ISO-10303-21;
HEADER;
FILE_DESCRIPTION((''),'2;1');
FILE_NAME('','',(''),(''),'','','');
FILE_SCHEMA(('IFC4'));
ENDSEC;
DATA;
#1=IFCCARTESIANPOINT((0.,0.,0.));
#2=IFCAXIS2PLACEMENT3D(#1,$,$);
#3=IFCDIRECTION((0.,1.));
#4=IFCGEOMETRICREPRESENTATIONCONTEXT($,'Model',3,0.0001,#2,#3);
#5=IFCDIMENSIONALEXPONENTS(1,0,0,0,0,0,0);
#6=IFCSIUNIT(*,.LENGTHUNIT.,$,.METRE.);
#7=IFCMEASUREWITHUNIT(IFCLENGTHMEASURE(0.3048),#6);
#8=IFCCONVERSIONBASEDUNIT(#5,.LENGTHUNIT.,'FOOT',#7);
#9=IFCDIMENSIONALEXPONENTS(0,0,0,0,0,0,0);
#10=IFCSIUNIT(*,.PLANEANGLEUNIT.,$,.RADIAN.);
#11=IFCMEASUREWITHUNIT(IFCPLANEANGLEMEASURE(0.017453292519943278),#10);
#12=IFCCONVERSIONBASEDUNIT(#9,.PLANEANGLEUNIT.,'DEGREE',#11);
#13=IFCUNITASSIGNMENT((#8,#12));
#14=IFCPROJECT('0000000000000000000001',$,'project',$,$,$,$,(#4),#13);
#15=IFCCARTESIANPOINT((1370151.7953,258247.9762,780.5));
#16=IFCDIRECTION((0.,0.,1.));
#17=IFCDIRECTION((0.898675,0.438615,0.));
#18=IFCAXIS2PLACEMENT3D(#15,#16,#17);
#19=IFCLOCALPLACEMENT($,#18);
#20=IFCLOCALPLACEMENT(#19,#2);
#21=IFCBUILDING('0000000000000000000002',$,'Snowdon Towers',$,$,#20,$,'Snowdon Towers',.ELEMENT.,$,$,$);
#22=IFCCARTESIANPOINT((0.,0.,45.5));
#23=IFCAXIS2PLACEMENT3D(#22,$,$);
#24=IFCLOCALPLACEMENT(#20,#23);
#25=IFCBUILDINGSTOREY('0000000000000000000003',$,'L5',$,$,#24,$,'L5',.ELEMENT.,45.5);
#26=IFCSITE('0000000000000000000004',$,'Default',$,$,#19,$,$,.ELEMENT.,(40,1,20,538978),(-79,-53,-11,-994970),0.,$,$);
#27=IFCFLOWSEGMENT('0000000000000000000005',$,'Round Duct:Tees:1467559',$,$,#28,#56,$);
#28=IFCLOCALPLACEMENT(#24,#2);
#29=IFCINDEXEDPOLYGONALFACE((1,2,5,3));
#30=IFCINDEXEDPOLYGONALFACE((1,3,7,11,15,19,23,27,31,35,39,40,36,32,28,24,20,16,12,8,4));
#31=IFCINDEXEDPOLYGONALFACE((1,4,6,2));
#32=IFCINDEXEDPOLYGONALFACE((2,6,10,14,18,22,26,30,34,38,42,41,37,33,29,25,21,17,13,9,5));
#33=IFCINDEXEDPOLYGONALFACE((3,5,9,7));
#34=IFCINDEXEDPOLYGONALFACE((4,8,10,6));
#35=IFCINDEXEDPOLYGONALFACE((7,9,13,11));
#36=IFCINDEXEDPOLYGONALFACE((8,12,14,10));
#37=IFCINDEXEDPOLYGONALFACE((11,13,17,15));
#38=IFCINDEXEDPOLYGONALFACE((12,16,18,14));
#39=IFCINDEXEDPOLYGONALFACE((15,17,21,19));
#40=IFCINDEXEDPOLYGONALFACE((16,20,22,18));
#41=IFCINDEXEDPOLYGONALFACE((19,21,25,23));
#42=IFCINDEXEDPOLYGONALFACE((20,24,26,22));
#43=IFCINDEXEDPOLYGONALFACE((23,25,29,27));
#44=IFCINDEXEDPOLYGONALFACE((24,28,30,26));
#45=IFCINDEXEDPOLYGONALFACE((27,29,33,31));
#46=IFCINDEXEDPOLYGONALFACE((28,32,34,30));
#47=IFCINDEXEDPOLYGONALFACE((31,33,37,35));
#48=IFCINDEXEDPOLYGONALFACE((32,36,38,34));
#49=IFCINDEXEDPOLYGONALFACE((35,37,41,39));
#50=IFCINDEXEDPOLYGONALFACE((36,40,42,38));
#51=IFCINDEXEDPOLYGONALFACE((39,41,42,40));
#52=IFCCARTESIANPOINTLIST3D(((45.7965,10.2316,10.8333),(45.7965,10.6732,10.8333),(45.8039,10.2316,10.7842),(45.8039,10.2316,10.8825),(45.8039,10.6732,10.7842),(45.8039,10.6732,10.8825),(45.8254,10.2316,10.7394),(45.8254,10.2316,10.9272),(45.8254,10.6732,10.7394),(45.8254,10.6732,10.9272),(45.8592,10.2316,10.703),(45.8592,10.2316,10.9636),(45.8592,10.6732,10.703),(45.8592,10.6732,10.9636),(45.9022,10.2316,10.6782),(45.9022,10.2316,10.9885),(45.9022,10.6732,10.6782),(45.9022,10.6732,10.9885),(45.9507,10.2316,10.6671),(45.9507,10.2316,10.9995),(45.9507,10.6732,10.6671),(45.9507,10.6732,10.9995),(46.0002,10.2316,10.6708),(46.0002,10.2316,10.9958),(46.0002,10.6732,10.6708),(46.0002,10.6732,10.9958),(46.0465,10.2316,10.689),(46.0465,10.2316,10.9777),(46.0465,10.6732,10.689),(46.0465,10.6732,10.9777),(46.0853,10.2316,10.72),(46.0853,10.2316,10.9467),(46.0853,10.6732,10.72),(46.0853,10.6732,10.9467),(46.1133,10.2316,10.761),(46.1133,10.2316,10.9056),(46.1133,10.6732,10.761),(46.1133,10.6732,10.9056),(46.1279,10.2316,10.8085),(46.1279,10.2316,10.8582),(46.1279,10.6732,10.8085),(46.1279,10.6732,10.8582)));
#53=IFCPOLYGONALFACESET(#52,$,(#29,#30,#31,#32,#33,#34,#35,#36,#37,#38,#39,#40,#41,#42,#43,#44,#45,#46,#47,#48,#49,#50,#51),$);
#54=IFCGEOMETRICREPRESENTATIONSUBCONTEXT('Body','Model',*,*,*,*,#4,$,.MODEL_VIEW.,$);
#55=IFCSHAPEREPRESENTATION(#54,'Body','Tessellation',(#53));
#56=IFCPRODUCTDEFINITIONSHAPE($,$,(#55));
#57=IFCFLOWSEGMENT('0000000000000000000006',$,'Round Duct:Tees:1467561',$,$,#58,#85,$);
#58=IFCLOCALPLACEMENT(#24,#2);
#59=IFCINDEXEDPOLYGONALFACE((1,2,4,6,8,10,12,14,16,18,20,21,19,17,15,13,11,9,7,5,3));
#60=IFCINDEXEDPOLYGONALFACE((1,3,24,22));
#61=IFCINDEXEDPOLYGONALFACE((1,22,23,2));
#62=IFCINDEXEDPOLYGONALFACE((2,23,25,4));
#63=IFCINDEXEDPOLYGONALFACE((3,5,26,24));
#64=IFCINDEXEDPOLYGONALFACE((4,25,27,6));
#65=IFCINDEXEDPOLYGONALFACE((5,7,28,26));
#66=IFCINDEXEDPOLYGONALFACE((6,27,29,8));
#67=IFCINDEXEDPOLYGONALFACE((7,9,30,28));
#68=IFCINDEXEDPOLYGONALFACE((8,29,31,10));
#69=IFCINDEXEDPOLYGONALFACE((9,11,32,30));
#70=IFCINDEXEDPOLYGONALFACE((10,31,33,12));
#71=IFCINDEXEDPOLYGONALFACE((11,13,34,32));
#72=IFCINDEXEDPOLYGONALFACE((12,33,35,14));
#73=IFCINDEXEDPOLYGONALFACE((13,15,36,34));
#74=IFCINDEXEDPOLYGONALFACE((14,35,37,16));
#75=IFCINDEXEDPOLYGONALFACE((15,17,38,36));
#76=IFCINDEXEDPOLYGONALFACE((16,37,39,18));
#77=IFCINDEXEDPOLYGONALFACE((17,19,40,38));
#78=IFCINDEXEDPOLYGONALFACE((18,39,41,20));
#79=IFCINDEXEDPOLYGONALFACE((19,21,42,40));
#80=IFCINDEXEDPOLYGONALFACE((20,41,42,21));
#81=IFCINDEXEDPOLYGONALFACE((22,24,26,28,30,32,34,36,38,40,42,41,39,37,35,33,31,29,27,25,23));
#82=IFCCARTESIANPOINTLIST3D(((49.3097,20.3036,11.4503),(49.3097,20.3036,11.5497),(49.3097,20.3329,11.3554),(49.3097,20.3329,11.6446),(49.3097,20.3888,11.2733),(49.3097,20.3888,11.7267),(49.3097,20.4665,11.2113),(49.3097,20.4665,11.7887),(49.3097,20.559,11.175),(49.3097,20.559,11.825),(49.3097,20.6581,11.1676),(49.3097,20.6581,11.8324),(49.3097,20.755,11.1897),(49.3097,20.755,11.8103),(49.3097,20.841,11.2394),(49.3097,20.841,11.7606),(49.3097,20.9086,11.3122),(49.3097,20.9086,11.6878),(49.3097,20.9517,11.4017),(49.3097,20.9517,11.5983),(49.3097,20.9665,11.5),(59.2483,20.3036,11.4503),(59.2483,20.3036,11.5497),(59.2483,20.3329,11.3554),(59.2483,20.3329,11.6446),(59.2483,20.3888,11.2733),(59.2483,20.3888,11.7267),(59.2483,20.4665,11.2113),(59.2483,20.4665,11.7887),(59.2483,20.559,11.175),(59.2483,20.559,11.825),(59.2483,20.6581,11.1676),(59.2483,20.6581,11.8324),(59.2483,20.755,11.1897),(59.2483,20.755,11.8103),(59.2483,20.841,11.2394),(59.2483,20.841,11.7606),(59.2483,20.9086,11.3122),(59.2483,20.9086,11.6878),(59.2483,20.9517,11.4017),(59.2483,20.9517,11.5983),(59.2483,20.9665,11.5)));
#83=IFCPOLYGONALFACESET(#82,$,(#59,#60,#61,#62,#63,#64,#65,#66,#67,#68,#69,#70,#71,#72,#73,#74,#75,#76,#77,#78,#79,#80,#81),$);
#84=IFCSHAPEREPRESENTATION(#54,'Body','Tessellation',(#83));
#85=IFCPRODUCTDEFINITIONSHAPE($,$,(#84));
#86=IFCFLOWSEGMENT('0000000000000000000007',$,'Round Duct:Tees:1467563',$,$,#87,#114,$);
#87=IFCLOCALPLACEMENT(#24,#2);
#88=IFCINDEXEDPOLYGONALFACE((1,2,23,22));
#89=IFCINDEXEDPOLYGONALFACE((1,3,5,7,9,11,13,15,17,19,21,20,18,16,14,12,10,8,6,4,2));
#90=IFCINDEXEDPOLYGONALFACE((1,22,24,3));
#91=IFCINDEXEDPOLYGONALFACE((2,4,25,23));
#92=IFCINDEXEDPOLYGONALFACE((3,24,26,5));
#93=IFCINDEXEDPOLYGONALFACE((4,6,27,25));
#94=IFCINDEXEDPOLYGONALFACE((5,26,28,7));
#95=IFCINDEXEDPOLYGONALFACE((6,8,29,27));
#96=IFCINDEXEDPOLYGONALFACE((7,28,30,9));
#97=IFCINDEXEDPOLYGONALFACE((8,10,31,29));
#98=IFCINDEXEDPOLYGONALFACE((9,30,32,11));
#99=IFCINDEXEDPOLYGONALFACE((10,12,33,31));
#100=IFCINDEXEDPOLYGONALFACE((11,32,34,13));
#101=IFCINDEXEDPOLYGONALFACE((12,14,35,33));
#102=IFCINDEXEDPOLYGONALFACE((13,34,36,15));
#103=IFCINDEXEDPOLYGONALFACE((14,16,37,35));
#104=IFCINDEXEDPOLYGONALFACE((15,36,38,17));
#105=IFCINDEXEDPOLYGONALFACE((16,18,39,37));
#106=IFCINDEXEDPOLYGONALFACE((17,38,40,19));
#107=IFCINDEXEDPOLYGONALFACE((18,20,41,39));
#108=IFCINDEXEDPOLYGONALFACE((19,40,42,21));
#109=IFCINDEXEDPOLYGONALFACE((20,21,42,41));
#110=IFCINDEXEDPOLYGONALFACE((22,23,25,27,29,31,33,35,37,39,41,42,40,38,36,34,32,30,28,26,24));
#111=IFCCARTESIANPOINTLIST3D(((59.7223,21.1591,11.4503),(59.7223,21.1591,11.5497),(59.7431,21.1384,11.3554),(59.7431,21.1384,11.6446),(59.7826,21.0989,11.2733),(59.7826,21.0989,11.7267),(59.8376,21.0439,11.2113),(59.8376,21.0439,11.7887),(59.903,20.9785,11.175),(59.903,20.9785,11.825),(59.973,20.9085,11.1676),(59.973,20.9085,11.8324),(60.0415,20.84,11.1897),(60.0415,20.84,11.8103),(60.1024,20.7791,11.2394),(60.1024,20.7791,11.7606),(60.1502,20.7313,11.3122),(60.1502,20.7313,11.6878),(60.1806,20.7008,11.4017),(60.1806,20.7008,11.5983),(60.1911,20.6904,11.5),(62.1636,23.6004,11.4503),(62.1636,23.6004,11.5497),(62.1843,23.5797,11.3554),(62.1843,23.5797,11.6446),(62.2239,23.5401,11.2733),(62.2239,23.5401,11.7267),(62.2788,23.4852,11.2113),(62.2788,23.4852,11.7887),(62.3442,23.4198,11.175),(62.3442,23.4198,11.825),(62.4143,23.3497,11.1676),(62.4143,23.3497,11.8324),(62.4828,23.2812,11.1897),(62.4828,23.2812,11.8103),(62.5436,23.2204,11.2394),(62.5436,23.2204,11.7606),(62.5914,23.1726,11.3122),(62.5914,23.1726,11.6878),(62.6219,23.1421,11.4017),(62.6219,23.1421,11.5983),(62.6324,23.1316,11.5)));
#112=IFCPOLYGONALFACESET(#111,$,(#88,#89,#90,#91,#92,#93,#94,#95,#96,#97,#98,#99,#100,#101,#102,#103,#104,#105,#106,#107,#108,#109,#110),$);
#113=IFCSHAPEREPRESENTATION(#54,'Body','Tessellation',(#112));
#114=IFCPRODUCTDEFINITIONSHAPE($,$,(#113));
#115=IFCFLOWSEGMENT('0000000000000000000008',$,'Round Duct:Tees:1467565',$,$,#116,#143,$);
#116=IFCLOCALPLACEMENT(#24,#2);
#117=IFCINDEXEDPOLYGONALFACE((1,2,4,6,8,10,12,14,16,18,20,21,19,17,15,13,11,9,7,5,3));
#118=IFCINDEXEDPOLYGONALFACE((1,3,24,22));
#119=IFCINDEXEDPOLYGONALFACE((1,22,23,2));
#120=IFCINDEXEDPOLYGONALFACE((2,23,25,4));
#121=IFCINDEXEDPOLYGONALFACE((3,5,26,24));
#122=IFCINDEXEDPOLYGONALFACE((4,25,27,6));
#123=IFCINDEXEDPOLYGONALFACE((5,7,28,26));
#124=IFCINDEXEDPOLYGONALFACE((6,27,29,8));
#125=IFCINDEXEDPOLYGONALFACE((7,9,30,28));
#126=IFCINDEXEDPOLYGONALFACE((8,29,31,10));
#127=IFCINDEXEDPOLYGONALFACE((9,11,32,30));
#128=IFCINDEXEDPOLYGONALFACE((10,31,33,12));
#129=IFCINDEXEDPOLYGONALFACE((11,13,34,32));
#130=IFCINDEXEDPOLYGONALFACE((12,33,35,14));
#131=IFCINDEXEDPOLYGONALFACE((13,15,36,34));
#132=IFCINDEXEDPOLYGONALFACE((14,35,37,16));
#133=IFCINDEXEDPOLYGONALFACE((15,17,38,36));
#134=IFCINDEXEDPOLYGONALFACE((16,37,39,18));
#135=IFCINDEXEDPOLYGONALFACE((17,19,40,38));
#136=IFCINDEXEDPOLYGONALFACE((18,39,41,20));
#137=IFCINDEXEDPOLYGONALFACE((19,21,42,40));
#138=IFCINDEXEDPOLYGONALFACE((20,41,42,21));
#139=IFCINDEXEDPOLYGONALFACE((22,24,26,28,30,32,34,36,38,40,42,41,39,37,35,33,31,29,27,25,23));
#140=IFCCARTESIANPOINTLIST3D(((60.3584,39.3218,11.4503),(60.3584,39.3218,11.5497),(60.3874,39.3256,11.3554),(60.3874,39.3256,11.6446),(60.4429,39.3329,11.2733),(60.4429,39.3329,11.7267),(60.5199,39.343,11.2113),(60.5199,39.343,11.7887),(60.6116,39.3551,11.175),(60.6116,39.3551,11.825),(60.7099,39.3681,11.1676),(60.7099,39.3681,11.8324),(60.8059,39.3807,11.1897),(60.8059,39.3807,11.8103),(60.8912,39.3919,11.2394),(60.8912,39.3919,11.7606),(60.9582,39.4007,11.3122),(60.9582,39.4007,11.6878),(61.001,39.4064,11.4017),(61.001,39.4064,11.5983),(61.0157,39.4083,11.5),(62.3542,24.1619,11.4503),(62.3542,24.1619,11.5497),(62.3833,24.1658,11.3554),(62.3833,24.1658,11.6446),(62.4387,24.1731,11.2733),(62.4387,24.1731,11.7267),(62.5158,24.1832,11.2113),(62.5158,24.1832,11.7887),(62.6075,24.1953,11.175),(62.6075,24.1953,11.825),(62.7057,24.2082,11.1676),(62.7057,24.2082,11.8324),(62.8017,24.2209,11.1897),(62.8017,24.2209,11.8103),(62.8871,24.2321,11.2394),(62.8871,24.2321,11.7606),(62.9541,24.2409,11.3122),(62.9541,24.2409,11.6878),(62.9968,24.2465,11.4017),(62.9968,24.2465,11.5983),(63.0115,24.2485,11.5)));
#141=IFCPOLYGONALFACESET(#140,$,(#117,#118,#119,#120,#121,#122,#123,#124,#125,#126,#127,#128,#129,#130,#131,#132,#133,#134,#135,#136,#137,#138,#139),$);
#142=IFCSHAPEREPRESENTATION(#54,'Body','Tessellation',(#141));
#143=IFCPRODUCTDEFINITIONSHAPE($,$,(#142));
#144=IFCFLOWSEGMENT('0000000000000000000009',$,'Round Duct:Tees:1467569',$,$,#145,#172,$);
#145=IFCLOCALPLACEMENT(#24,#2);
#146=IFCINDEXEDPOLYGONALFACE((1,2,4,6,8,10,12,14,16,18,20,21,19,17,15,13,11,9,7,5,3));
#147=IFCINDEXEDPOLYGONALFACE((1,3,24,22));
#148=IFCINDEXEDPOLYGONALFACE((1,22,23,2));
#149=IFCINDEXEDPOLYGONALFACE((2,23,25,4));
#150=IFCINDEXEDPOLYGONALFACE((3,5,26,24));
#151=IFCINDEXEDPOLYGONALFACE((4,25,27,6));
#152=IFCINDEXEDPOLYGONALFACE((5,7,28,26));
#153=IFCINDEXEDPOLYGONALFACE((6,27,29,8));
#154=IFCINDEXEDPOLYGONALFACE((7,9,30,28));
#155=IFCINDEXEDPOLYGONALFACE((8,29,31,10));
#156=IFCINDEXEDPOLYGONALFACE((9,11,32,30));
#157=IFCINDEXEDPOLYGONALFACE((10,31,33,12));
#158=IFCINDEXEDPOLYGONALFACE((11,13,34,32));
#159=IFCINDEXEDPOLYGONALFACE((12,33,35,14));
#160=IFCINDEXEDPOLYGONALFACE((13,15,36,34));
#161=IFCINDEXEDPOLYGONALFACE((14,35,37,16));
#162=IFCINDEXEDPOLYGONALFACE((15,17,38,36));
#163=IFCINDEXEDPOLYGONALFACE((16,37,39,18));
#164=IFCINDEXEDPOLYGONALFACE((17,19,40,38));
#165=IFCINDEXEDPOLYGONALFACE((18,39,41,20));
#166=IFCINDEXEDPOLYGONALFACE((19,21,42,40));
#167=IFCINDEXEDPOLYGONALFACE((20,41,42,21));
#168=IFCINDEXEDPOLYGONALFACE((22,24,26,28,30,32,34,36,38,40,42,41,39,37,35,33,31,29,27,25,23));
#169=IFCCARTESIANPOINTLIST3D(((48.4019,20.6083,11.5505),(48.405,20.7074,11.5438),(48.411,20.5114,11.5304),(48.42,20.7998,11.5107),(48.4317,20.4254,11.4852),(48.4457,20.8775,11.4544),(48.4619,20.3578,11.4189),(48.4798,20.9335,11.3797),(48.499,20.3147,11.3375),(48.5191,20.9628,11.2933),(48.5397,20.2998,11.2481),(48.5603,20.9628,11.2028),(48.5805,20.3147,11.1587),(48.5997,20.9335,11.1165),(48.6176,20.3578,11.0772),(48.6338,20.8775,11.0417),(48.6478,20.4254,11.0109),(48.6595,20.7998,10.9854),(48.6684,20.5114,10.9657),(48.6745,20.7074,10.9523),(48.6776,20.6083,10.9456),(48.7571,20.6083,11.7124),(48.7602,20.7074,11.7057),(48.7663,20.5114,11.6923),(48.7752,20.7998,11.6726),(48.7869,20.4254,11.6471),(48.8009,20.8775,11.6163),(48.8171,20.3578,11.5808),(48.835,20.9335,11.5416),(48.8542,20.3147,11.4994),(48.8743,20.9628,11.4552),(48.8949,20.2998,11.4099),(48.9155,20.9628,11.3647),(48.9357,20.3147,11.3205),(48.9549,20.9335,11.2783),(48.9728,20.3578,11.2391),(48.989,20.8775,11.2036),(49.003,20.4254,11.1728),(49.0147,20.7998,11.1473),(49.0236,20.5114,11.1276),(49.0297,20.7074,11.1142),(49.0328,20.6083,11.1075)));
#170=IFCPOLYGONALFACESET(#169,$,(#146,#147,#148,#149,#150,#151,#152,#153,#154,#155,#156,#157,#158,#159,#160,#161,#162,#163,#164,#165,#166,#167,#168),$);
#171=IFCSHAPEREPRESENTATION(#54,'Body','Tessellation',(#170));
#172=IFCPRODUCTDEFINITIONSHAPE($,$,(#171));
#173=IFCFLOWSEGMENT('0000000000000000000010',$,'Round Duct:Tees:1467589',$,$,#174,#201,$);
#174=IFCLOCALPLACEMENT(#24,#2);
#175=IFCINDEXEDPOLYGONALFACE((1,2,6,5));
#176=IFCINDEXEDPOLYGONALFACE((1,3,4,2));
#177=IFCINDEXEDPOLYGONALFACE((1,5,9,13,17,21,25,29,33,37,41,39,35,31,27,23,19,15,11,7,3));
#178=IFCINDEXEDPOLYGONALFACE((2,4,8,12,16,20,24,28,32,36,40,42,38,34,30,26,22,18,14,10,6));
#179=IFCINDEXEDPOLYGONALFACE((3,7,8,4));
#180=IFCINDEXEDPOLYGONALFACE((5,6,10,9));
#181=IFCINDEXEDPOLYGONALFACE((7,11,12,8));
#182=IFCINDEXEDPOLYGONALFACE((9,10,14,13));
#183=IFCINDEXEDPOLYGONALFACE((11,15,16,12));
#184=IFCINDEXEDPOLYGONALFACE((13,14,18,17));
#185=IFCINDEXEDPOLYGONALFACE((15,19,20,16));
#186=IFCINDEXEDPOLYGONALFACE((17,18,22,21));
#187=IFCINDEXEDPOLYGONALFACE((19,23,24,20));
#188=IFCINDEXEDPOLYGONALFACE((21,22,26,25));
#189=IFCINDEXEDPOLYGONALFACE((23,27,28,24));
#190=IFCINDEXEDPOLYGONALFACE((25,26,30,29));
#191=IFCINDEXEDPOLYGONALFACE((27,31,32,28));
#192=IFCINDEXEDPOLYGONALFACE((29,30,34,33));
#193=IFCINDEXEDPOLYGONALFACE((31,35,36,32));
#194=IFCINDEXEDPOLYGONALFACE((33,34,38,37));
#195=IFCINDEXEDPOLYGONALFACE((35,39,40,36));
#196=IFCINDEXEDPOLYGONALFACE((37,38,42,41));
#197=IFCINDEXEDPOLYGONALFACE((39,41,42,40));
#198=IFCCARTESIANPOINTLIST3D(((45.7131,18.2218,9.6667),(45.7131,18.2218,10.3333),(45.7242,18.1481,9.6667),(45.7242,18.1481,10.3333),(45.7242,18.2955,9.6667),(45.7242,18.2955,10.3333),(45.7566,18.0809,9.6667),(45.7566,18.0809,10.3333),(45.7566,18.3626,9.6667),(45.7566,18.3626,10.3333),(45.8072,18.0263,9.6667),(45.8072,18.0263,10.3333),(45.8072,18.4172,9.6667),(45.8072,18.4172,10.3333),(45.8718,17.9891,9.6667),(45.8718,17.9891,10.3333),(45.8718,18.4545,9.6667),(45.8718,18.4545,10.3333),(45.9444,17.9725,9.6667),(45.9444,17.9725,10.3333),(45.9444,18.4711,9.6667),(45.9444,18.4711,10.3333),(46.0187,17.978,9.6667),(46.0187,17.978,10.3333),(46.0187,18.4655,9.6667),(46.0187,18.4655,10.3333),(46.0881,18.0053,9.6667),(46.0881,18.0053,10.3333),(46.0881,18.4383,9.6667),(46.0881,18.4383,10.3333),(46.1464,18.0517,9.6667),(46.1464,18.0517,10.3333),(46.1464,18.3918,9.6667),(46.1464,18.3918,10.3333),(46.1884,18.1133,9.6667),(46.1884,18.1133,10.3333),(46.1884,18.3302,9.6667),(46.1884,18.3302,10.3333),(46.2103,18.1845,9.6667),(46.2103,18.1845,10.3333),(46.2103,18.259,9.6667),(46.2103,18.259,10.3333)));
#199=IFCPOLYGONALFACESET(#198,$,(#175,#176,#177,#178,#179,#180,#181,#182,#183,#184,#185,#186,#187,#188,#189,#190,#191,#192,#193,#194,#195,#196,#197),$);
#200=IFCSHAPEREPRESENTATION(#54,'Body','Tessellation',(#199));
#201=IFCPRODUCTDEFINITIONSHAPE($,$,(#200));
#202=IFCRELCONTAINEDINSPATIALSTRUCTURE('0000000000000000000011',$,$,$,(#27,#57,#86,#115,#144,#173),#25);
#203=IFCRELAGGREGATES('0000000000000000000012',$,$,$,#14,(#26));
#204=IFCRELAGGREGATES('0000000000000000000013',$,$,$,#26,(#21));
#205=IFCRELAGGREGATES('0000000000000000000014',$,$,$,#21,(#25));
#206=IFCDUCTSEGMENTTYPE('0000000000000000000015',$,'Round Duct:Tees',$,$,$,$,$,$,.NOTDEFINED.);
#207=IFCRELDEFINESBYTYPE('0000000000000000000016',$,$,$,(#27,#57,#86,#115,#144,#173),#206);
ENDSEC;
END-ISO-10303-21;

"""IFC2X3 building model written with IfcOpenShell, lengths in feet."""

from ifc_helpers import new_model, entity, si_unit, converted_unit, direction, frame, frame_2d, origin, origin_2d_with_axis, place, context, subcontext, project, spatial, circle, extrude, type_object, element, save


model = new_model("IFC2X3")

# Units and contexts
model_context = context("Model", 3, precision=0.0001, world=origin(), true_north=direction((0.0, 1.0)))
body_context = subcontext(model_context, "Body", "Model", "MODEL_VIEW")
ifc_project = project(units=[converted_unit("LENGTHUNIT", "FOOT", entity("IfcLengthMeasure", 0.3048), si_unit("LENGTHUNIT", "METRE"), dimensions=[1, 0, 0, 0, 0, 0, 0]), converted_unit("PLANEANGLEUNIT", "DEGREE", entity("IfcPlaneAngleMeasure", 0.017453292519943278), si_unit("PLANEANGLEUNIT", "RADIAN"), dimensions=[0, 0, 0, 0, 0, 0, 0])], contexts=[model_context])

# Site, building, storey
site_placement = place(None, frame((1370151.7953, 258247.9762, 780.5), z_axis=(0.0, 0.0, 1.0), x_axis=(0.898675, 0.438615, 0.0)))
site = spatial("IfcSite", under=ifc_project, at=site_placement, Name="Default", CompositionType="ELEMENT", RefLatitude=(40, 1, 20, 538978), RefLongitude=(-79, -53, -11, -994970), RefElevation=0.0)
building_placement = place(site_placement, origin())
building = spatial("IfcBuilding", under=site, at=building_placement, Name="Snowdon Towers", LongName="Snowdon Towers", CompositionType="ELEMENT")
storey_placement = place(building_placement, frame((0.0, 0.0, 45.5)))
storey = spatial("IfcBuildingStorey", under=building, at=storey_placement, Name="L5", LongName="L5", CompositionType="ELEMENT", Elevation=45.5)

# Flow segments
duct_segment_type = type_object("IfcDuctSegmentType", Name="Round Duct:Tees", PredefinedType="NOTDEFINED")
flow_segment_1_placement = place(storey_placement, origin())
element("IfcFlowSegment", 1, at=flow_segment_1_placement, inside=storey, type_object=duct_segment_type, Name="Round Duct:Tees:1467559", context=body_context, shape_type="SweptSolid", body=[
    extrude(circle(Radius=0.1667, at=origin_2d_with_axis()), frame((45.9631, 10.2316, 10.8333), z_axis=(0.0, 1.0, 0.0), x_axis=(-1.0, 0.0, 0.0)), (0.0, 0.0, 1.0), 0.4416),
])
flow_segment_2_placement = place(storey_placement, origin())
element("IfcFlowSegment", 2, at=flow_segment_2_placement, inside=storey, type_object=duct_segment_type, Name="Round Duct:Tees:1467561", context=body_context, shape_type="SweptSolid", body=[
    extrude(circle(Radius=0.3333, at=frame_2d((0.0, 0.0), x_axis=(1.0, 0.0))), frame((49.3097, 20.6332, 11.5), z_axis=(1.0, 0.0, 0.0), x_axis=(0.0, 1.0, 0.0)), (0.0, 0.0, 1.0), 9.9386),
])
flow_segment_3_placement = place(storey_placement, origin())
element("IfcFlowSegment", 3, at=flow_segment_3_placement, inside=storey, type_object=duct_segment_type, Name="Round Duct:Tees:1467563", context=body_context, shape_type="SweptSolid", body=[
    extrude(circle(Radius=0.3333, at=origin_2d_with_axis()), frame((59.9554, 20.9261, 11.5), z_axis=(0.707107, 0.707107, 0.0), x_axis=(0.707107, -0.707107, 0.0)), (0.0, 0.0, 1.0), 3.4525),
])
flow_segment_4_placement = place(storey_placement, origin())
element("IfcFlowSegment", 4, at=flow_segment_4_placement, inside=storey, type_object=duct_segment_type, Name="Round Duct:Tees:1467565", context=body_context, shape_type="SweptSolid", body=[
    extrude(circle(Radius=0.3333, at=frame_2d((0.0, 0.0), x_axis=(1.0, 0.0))), frame((62.681, 24.205, 11.5), z_axis=(-0.130526, 0.991445, 0.0), x_axis=(0.991445, 0.130526, 0.0)), (0.0, 0.0, 1.0), 15.2907),
])
flow_segment_5_placement = place(storey_placement, origin())
element("IfcFlowSegment", 5, at=flow_segment_5_placement, inside=storey, type_object=duct_segment_type, Name="Round Duct:Tees:1467569", context=body_context, shape_type="SweptSolid", body=[
    extrude(circle(Radius=0.3333, at=frame_2d((0.0, 0.0), x_axis=(1.0, 0.0))), frame((48.5397, 20.6332, 11.2481), z_axis=(0.909948, 0.0, 0.414723), x_axis=(0.0, -1.0, 0.0)), (0.0, 0.0, 1.0), 0.3904),
])
flow_segment_6_placement = place(storey_placement, origin())
element("IfcFlowSegment", 6, at=flow_segment_6_placement, inside=storey, type_object=duct_segment_type, Name="Round Duct:Tees:1467589", context=body_context, shape_type="SweptSolid", body=[
    extrude(circle(Radius=0.25, at=frame_2d((0.0, 0.0), x_axis=(1.0, 0.0))), frame((45.9631, 18.2218, 9.6667), z_axis=(0.0, 0.0, 1.0), x_axis=(-1.0, 0.0, 0.0)), (0.0, 0.0, 1.0), 0.6667),
])

save(model, "model.ifc")
